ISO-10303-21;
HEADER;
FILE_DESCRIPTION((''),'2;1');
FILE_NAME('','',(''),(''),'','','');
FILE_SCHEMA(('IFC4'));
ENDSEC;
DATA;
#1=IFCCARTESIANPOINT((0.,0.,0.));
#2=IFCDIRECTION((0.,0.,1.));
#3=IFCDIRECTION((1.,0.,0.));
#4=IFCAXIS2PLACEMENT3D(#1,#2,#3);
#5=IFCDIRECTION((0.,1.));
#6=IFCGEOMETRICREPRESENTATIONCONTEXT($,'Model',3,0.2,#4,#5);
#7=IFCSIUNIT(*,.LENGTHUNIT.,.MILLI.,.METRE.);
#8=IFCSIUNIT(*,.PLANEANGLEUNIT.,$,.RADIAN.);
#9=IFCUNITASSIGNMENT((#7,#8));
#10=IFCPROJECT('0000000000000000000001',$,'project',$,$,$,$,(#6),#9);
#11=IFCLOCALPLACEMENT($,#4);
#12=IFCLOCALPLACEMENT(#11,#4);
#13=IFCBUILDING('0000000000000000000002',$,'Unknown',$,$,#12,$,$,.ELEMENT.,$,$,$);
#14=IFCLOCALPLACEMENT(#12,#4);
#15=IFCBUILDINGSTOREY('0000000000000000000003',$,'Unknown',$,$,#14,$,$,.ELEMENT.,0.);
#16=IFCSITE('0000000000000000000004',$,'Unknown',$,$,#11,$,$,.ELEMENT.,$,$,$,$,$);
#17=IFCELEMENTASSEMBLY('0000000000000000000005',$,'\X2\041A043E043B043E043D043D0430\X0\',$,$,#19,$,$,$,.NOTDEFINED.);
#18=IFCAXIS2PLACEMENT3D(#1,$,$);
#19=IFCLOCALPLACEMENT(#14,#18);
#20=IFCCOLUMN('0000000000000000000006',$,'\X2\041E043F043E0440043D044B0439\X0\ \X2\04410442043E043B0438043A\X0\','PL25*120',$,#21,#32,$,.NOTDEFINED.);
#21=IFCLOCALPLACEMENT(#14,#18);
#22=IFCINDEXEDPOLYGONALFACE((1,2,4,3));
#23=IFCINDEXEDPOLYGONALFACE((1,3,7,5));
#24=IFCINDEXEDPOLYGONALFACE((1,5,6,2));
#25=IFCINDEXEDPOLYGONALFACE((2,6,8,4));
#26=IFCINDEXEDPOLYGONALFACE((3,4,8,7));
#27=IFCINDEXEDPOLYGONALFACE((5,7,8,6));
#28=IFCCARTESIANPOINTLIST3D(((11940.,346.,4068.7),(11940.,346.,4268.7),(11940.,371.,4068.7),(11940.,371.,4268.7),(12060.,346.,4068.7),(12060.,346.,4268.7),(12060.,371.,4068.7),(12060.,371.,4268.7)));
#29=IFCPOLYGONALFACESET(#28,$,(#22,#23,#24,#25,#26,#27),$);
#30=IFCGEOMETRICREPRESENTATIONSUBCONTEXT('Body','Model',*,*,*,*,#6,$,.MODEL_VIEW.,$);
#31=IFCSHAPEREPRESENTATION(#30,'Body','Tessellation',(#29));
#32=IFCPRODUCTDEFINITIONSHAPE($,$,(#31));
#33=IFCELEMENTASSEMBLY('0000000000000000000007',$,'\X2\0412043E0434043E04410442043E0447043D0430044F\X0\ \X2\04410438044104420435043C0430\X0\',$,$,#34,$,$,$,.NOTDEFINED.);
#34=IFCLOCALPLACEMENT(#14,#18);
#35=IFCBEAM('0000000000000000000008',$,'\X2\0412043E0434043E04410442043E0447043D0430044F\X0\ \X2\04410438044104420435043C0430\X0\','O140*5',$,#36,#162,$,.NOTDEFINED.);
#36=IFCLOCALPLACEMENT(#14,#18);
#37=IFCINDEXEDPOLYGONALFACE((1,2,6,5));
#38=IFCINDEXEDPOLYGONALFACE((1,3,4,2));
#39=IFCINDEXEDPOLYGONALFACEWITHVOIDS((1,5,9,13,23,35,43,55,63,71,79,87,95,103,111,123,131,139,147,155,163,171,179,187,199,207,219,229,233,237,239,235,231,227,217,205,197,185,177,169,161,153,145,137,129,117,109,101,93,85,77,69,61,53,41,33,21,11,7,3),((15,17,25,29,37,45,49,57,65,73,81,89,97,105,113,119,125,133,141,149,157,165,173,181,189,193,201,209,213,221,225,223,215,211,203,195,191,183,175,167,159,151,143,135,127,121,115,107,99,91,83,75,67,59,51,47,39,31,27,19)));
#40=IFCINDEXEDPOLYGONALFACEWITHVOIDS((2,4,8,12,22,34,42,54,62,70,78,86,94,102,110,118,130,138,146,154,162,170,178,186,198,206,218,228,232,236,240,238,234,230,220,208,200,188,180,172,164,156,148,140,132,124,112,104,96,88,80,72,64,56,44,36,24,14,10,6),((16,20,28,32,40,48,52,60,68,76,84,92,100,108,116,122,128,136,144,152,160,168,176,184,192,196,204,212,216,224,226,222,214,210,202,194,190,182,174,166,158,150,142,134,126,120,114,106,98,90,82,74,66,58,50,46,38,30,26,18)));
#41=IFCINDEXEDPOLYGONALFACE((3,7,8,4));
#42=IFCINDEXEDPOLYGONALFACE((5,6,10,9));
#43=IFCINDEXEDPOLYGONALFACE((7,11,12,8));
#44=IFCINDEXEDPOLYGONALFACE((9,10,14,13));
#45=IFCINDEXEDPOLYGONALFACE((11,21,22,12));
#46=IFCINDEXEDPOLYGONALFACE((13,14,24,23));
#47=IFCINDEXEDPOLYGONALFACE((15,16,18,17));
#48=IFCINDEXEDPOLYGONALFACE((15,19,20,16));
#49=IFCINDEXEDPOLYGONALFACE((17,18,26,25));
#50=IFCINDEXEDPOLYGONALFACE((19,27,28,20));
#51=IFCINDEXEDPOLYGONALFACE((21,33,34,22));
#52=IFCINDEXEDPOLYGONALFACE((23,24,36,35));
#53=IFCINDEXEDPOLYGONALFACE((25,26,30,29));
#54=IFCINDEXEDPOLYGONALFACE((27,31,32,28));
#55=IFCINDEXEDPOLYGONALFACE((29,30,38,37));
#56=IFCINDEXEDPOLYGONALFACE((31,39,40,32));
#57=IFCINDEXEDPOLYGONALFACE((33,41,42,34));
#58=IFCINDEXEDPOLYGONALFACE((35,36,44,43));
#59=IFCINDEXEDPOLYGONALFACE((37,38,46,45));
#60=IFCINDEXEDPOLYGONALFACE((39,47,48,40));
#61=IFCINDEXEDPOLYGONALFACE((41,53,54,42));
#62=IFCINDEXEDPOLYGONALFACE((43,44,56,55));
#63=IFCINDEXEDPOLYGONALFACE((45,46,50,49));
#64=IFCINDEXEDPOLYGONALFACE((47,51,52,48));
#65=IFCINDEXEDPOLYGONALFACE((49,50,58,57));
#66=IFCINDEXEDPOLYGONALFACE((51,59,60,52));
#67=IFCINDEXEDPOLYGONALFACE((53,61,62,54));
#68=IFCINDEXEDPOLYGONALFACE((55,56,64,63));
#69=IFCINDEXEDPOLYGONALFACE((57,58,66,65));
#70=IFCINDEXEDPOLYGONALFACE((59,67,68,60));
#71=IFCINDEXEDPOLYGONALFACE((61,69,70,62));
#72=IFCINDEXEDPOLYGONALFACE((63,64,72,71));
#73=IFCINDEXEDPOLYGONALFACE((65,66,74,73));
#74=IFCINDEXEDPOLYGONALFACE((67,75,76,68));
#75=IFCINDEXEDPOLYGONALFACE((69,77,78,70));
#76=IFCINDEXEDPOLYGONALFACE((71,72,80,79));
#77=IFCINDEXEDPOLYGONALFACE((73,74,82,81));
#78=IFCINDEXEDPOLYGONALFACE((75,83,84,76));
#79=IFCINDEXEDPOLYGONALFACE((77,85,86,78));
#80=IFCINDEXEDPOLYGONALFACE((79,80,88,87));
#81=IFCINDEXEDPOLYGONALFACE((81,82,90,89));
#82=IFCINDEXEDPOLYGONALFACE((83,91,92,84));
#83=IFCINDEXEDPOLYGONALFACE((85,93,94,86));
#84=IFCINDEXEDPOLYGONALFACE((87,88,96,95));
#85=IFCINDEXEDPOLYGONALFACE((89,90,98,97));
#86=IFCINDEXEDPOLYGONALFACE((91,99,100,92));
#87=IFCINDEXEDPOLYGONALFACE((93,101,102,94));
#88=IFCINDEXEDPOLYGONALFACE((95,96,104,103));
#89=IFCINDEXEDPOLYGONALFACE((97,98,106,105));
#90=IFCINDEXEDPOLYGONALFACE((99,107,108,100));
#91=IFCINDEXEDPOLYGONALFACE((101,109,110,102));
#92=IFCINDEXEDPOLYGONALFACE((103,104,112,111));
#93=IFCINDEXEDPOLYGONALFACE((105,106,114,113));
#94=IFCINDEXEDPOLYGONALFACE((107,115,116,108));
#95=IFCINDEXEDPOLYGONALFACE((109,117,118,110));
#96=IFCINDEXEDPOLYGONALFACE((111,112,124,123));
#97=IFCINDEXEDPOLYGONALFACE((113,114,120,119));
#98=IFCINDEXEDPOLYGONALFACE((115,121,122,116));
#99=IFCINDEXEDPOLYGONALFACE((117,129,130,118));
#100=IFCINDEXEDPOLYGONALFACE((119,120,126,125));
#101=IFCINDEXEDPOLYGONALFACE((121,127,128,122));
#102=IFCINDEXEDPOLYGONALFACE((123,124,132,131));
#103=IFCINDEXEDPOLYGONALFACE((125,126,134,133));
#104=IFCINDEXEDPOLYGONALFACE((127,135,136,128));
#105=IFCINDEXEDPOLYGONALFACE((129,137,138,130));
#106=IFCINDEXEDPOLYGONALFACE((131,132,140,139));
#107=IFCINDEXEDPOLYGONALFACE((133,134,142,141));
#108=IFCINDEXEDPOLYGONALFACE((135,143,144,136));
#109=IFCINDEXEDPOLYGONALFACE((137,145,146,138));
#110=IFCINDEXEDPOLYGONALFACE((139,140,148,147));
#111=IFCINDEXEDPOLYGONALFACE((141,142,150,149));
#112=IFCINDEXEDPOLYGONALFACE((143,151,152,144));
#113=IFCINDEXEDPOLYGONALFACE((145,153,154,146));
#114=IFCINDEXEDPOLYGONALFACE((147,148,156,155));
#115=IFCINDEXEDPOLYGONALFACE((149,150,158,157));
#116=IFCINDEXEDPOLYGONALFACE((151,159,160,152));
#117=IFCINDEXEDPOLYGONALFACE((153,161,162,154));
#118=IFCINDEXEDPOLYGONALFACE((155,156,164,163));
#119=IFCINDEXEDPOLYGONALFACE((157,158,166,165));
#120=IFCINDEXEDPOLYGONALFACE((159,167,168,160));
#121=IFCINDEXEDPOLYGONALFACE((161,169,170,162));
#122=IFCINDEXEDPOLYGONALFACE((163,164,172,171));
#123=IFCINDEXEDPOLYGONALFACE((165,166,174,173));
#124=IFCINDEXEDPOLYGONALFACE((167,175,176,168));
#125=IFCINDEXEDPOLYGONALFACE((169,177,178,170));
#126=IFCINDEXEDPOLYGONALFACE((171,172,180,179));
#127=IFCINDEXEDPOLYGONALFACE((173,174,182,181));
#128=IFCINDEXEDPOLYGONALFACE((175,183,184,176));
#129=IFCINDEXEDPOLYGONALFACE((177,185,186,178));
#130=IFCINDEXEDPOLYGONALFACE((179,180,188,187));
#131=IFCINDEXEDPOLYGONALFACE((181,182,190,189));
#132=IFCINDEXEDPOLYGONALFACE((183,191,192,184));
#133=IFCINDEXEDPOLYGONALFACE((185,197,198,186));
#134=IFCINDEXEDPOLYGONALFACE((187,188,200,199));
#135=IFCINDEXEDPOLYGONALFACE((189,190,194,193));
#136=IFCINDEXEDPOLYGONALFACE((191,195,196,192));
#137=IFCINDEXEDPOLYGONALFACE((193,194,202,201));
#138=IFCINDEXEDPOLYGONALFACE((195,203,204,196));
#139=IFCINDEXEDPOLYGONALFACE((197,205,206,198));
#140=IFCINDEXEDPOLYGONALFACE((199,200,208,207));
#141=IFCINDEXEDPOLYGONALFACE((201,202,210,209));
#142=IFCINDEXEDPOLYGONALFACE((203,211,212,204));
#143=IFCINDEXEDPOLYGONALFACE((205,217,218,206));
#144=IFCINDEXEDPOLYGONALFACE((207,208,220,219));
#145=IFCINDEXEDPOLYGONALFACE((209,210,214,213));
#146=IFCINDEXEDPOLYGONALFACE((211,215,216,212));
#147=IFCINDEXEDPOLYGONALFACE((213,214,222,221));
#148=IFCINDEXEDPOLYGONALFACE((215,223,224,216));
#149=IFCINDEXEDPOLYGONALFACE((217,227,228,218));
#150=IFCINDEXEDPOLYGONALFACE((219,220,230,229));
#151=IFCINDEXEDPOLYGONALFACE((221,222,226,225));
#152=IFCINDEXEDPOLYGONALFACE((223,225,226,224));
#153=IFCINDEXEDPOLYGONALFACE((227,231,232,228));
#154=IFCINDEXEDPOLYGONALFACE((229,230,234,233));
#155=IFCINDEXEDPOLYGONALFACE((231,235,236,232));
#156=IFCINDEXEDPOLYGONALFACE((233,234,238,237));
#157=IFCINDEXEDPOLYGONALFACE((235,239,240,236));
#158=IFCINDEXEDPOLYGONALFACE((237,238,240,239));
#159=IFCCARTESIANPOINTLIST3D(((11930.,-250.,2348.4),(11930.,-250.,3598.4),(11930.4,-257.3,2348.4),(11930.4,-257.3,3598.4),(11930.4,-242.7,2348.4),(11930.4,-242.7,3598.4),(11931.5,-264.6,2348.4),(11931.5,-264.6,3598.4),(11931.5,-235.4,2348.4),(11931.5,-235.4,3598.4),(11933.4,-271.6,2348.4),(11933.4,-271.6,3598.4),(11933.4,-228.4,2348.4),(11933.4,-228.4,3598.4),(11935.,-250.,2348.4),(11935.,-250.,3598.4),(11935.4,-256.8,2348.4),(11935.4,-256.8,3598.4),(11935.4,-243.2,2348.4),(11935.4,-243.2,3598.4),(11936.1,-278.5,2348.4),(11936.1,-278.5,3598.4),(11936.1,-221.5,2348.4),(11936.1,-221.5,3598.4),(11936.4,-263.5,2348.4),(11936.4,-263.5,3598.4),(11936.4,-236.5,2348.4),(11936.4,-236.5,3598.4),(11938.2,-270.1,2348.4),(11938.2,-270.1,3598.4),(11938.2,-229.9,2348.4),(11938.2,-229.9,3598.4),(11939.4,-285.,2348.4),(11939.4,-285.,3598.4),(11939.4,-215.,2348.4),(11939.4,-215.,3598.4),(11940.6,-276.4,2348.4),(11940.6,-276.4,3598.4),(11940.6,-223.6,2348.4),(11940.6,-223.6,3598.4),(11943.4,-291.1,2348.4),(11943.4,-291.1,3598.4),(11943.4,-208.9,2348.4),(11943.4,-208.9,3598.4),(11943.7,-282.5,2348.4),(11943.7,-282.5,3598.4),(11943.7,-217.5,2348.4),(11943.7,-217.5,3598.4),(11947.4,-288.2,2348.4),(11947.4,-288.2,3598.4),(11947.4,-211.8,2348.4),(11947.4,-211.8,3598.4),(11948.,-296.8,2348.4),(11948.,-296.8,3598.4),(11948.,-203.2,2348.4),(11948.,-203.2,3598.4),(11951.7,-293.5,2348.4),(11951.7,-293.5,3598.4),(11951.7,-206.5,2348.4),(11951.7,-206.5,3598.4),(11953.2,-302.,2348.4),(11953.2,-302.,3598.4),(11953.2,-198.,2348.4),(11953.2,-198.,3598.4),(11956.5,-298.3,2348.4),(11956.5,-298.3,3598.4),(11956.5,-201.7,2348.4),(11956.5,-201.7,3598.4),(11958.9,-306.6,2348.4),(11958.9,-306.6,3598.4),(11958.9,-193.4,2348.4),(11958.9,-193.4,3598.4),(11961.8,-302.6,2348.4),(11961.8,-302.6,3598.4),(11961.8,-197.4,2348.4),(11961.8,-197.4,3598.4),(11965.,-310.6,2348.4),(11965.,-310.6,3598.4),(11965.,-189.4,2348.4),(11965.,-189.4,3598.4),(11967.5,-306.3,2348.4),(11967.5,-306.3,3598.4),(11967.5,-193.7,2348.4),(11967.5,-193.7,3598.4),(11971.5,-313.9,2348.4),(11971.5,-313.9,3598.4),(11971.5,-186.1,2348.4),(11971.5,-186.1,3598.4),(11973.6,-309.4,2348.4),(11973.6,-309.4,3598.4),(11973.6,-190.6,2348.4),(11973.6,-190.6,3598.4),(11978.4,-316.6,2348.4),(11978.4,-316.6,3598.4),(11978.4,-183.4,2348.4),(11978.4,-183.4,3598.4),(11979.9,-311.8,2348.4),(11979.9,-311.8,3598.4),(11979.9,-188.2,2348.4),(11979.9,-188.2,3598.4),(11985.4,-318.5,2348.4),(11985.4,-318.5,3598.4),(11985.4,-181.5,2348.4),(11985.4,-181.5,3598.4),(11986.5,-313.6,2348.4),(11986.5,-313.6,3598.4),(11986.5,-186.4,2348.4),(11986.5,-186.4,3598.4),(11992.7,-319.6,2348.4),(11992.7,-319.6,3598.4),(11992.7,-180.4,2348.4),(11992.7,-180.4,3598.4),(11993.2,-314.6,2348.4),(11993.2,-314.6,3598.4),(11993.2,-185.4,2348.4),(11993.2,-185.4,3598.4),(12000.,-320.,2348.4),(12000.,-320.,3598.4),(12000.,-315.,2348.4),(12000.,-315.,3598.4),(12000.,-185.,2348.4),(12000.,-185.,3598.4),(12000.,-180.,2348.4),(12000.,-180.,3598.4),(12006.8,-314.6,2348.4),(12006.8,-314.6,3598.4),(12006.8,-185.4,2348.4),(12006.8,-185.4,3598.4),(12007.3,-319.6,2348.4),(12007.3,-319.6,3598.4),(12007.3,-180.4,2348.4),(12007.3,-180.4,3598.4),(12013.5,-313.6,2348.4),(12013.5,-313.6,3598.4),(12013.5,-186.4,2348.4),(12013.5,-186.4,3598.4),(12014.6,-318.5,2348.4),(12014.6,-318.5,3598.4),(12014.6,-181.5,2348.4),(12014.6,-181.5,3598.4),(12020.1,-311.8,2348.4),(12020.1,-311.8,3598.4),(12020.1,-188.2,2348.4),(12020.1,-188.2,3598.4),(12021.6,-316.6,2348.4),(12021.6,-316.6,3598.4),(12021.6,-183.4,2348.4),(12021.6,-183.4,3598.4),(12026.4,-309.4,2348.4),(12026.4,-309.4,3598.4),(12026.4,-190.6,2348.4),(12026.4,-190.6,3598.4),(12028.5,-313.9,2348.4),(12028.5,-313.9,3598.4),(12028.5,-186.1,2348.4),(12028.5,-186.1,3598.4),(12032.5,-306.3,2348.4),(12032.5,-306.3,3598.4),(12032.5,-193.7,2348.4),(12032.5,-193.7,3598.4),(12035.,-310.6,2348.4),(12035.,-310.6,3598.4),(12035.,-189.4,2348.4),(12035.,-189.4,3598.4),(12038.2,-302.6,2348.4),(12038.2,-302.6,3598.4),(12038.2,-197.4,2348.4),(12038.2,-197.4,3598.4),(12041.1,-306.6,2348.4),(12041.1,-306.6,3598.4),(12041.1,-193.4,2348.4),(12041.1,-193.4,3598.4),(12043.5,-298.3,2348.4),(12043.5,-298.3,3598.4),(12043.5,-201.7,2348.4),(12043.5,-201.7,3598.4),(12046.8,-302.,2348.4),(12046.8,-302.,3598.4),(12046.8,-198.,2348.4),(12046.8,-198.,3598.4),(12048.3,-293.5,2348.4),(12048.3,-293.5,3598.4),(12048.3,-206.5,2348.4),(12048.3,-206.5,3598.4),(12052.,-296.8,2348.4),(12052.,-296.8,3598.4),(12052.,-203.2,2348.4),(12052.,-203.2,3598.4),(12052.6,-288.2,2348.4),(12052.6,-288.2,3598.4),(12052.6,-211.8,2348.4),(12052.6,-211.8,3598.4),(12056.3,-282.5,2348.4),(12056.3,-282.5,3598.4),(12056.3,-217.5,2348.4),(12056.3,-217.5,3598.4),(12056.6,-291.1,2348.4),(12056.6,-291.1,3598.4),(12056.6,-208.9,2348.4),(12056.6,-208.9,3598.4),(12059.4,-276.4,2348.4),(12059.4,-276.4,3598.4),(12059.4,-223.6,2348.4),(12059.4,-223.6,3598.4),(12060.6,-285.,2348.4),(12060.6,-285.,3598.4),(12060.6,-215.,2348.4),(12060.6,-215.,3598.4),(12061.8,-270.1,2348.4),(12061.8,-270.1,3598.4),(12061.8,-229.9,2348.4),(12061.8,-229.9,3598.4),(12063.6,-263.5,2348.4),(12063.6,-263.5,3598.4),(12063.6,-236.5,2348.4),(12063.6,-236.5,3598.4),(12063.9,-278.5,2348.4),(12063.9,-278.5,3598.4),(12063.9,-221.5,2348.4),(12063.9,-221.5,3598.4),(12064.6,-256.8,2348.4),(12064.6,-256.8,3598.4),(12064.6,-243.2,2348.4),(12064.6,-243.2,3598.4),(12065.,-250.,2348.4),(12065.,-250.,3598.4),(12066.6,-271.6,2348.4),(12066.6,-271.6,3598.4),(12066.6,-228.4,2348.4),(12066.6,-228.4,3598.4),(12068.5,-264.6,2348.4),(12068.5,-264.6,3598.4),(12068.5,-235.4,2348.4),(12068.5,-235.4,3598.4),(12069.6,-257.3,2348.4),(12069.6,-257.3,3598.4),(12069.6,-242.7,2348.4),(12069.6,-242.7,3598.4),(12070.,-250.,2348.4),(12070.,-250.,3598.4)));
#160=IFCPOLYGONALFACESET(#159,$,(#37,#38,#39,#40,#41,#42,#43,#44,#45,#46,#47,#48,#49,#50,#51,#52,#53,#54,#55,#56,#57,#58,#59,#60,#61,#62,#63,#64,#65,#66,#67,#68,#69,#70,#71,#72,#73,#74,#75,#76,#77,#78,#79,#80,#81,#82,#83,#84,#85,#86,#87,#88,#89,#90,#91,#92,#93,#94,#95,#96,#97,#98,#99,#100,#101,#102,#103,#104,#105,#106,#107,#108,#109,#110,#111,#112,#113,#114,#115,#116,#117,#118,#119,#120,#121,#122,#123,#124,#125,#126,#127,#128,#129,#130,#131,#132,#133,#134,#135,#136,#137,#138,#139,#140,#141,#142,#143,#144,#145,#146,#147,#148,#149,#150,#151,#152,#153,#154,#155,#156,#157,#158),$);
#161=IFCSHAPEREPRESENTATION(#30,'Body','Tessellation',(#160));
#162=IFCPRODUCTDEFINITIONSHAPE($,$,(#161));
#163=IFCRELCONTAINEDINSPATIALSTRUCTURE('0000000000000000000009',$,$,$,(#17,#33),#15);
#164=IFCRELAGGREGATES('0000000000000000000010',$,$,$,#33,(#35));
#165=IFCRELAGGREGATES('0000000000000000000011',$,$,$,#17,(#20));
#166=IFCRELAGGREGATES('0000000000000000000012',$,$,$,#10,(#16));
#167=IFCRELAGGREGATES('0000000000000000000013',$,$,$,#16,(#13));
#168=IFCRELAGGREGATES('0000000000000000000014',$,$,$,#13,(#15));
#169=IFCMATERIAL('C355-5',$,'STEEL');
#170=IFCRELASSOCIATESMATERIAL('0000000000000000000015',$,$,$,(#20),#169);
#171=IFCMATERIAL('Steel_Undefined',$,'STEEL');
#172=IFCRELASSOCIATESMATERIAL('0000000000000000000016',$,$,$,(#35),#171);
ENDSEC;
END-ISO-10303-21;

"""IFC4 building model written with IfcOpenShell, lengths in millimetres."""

from ifc_helpers import new_model, si_unit, direction, frame, origin_with_axes, place, context, subcontext, project, spatial, line, indexed_curve, outline, extrude, material, element, aggregate, save


model = new_model("IFC4")

# Units and contexts
model_context = context("Model", 3, precision=0.2, world=origin_with_axes(), true_north=direction((0.0, 1.0)))
body_context = subcontext(model_context, "Body", "Model", "MODEL_VIEW")
ifc_project = project(units=[si_unit("LENGTHUNIT", "METRE", prefix="MILLI"), si_unit("PLANEANGLEUNIT", "RADIAN")], contexts=[model_context])

# Site, building, storey
site_placement = place(None, origin_with_axes())
site = spatial("IfcSite", under=ifc_project, at=site_placement, Name="Unknown", CompositionType="ELEMENT")
building_placement = place(site_placement, origin_with_axes())
building = spatial("IfcBuilding", under=site, at=building_placement, Name="Unknown", CompositionType="ELEMENT")
storey_placement = place(building_placement, origin_with_axes())
storey = spatial("IfcBuildingStorey", under=building, at=storey_placement, Name="Unknown", CompositionType="ELEMENT", Elevation=0.0)

# Element assembly, column
assembly_1_placement = place(storey_placement, frame((12000.0, 173.0, -200.0), z_axis=(-1.0, 0.0, 0.0), x_axis=(0.0, 0.0, 1.0)))
assembly_1 = element("IfcElementAssembly", 1, at=assembly_1_placement, inside=storey, Name="Колонна", PredefinedType="NOTDEFINED")
ifc_material_1 = material(Name="C355-5", Category="STEEL")
column_1_placement = place(assembly_1_placement, frame((4268.7, 185.5, 0.0), z_axis=(0.0, 1.0, 0.0), x_axis=(1.0, 0.0, 0.0)))
column_1 = element("IfcColumn", 2, at=column_1_placement, material=ifc_material_1, Name="Опорный столик", Description="PL25*120", PredefinedType="NOTDEFINED", context=body_context, shape_type="SolidModel", body=[
    extrude(outline(indexed_curve([(-12.5, -60.0), (12.5, -60.0), (12.5, 60.0), (-12.5, 60.0)], segments=[line(1, 2, 3, 4, 1)])), frame((0.0, 0.0, 0.0), z_axis=(-1.0, 0.0, 0.0), x_axis=(0.0, 0.0, 1.0)), (0.0, 0.0, -1.0), 200.0),
])

# Element assembly, beam
ifc_material_2 = material(Name="Steel_Undefined", Category="STEEL")
assembly_2_placement = place(storey_placement, frame((12000.0, -250.0, 3598.4), z_axis=(0.0, 1.0, 0.0), x_axis=(0.0, 0.0, -1.0)))
assembly_2 = element("IfcElementAssembly", 3, at=assembly_2_placement, inside=storey, Name="Водосточная система", PredefinedType="NOTDEFINED")
beam_1_placement = place(assembly_2_placement, origin_with_axes())
beam_1 = element("IfcBeam", 4, at=beam_1_placement, material=ifc_material_2, Name="Водосточная система", Description="O140*5", PredefinedType="NOTDEFINED", context=body_context, shape_type="SolidModel", body=[
    extrude(outline(indexed_curve([(70.0, 0.0), (69.6, 7.3), (68.5, 14.6), (66.6, 21.6), (63.9, 28.5), (60.6, 35.0), (56.6, 41.1), (52.0, 46.8), (46.8, 52.0), (41.1, 56.6), (35.0, 60.6), (28.5, 63.9), (21.6, 66.6), (14.6, 68.5), (7.3, 69.6), (0.0, 70.0), (-7.3, 69.6), (-14.6, 68.5), (-21.6, 66.6), (-28.5, 63.9), (-35.0, 60.6), (-41.1, 56.6), (-46.8, 52.0), (-52.0, 46.8), (-56.6, 41.1), (-60.6, 35.0), (-63.9, 28.5), (-66.6, 21.6), (-68.5, 14.6), (-69.6, 7.3), (-70.0, 0.0), (-69.6, -7.3), (-68.5, -14.6), (-66.6, -21.6), (-63.9, -28.5), (-60.6, -35.0), (-56.6, -41.1), (-52.0, -46.8), (-46.8, -52.0), (-41.1, -56.6), (-35.0, -60.6), (-28.5, -63.9), (-21.6, -66.6), (-14.6, -68.5), (-7.3, -69.6), (0.0, -70.0), (7.3, -69.6), (14.6, -68.5), (21.6, -66.6), (28.5, -63.9), (35.0, -60.6), (41.1, -56.6), (46.8, -52.0), (52.0, -46.8), (56.6, -41.1), (60.6, -35.0), (63.9, -28.5), (66.6, -21.6), (68.5, -14.6), (69.6, -7.3)], segments=[line(1, 2, 3, 4, 5, 6, 7, 8, 9, 10, 11, 12, 13, 14, 15, 16, 17, 18, 19, 20, 21, 22, 23, 24, 25, 26, 27, 28, 29, 30, 31, 32, 33, 34, 35, 36, 37, 38, 39, 40, 41, 42, 43, 44, 45, 46, 47, 48, 49, 50, 51, 52, 53, 54, 55, 56, 57, 58, 59, 60, 1)]), holes=[indexed_curve([(65.0, 0.0), (64.6, -6.8), (63.6, -13.5), (61.8, -20.1), (59.4, -26.4), (56.3, -32.5), (52.6, -38.2), (48.3, -43.5), (43.5, -48.3), (38.2, -52.6), (32.5, -56.3), (26.4, -59.4), (20.1, -61.8), (13.5, -63.6), (6.8, -64.6), (0.0, -65.0), (-6.8, -64.6), (-13.5, -63.6), (-20.1, -61.8), (-26.4, -59.4), (-32.5, -56.3), (-38.2, -52.6), (-43.5, -48.3), (-48.3, -43.5), (-52.6, -38.2), (-56.3, -32.5), (-59.4, -26.4), (-61.8, -20.1), (-63.6, -13.5), (-64.6, -6.8), (-65.0, 0.0), (-64.6, 6.8), (-63.6, 13.5), (-61.8, 20.1), (-59.4, 26.4), (-56.3, 32.5), (-52.6, 38.2), (-48.3, 43.5), (-43.5, 48.3), (-38.2, 52.6), (-32.5, 56.3), (-26.4, 59.4), (-20.1, 61.8), (-13.5, 63.6), (-6.8, 64.6), (0.0, 65.0), (6.8, 64.6), (13.5, 63.6), (20.1, 61.8), (26.4, 59.4), (32.5, 56.3), (38.2, 52.6), (43.5, 48.3), (48.3, 43.5), (52.6, 38.2), (56.3, 32.5), (59.4, 26.4), (61.8, 20.1), (63.6, 13.5), (64.6, 6.8)], segments=[line(1, 2, 3, 4, 5, 6, 7, 8, 9, 10, 11, 12, 13, 14, 15, 16, 17, 18, 19, 20, 21, 22, 23, 24, 25, 26, 27, 28, 29, 30, 31, 32, 33, 34, 35, 36, 37, 38, 39, 40, 41, 42, 43, 44, 45, 46, 47, 48, 49, 50, 51, 52, 53, 54, 55, 56, 57, 58, 59, 60, 1)])]), frame((0.0, 0.0, 0.0), z_axis=(-1.0, 0.0, 0.0), x_axis=(0.0, 0.0, 1.0)), (0.0, 0.0, -1.0), 1250.0),
])
aggregate(assembly_2, [beam_1])

aggregate(assembly_1, [column_1])

save(model, "model.ifc")
